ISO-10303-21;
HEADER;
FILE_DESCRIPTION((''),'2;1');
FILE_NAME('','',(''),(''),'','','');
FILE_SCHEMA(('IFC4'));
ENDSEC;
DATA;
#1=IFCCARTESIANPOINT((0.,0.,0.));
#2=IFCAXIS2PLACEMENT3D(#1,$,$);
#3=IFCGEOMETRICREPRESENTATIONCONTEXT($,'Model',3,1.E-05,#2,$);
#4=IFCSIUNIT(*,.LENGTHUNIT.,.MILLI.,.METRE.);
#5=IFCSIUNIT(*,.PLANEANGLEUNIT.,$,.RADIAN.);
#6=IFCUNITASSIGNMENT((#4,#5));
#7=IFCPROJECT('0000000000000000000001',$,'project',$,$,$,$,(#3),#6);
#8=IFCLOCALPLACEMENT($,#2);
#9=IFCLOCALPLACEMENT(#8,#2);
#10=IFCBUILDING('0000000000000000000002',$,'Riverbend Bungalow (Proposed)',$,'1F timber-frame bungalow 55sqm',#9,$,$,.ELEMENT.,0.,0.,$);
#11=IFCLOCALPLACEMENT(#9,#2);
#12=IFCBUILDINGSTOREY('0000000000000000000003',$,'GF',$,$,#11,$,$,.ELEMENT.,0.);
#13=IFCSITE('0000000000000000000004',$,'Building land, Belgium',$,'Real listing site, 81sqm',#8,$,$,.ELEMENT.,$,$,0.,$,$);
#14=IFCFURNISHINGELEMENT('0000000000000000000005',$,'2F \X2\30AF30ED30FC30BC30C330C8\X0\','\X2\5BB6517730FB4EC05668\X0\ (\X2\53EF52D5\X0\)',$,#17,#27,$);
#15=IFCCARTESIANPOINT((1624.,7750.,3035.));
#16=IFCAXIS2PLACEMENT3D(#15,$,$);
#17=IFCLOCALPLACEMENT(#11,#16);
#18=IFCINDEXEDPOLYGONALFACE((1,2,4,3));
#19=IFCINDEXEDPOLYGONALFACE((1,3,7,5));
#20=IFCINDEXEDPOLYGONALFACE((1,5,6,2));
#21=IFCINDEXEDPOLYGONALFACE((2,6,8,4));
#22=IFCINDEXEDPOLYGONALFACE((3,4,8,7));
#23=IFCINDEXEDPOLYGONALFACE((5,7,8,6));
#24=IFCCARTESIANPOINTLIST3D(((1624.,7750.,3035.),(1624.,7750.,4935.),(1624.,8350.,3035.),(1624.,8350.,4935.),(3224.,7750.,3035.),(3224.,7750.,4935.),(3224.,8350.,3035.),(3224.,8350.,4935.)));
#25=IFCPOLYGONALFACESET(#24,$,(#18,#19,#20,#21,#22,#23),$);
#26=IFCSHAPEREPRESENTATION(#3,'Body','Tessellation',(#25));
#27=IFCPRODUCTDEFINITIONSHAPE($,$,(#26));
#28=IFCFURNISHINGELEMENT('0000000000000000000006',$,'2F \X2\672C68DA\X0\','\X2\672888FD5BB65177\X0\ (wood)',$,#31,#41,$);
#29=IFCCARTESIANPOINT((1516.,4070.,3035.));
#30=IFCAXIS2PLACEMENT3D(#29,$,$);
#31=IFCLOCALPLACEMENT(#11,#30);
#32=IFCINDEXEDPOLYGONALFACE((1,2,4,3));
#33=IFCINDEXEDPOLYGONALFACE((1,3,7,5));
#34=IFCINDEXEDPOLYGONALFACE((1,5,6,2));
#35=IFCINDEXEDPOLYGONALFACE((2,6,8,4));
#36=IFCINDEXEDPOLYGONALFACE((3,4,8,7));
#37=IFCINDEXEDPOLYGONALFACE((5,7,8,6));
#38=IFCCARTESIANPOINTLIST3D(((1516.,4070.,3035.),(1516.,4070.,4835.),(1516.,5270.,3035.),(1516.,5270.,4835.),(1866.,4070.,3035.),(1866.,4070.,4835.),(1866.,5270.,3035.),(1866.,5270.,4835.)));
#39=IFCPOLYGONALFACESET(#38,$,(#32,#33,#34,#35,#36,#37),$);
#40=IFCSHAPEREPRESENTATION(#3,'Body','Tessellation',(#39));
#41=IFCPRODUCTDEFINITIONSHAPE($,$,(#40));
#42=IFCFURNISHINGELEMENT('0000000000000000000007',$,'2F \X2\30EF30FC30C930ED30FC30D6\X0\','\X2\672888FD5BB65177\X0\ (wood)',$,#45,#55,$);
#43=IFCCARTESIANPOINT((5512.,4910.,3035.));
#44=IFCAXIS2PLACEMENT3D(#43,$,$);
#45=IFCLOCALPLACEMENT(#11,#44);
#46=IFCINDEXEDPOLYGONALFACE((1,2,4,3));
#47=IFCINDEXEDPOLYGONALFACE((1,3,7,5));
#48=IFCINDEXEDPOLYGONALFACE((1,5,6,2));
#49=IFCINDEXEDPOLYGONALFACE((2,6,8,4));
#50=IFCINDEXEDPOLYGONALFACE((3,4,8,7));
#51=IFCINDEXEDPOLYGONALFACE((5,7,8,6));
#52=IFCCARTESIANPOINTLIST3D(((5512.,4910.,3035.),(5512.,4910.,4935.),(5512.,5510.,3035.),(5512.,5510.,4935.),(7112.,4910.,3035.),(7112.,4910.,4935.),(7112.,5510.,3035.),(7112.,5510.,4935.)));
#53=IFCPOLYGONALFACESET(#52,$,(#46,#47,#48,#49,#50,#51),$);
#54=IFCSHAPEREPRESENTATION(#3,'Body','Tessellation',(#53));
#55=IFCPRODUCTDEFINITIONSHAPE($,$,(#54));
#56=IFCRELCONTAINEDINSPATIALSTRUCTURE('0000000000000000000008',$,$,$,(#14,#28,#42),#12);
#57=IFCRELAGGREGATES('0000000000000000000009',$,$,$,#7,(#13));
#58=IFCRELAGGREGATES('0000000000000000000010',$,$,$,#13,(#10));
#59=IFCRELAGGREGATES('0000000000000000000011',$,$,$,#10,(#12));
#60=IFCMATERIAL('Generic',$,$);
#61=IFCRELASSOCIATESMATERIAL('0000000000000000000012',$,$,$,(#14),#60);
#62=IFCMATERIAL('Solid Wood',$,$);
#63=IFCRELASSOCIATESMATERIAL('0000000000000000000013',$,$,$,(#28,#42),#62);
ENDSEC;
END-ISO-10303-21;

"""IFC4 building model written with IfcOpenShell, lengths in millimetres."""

from ifc_helpers import new_model, si_unit, frame, frame_2d, origin, place, context, project, spatial, rectangle, extrude, material, element, save


model = new_model("IFC4")

# Units and contexts
model_context = context("Model", 3, precision=1e-05, world=origin())
ifc_project = project(units=[si_unit("LENGTHUNIT", "METRE", prefix="MILLI"), si_unit("PLANEANGLEUNIT", "RADIAN")], contexts=[model_context])

# Site, building, storey
site_placement = place(None, origin())
site = spatial("IfcSite", under=ifc_project, at=site_placement, Name="Building land, Belgium", ObjectType="Real listing site, 81sqm", CompositionType="ELEMENT", RefElevation=0.0)
building_placement = place(site_placement, origin())
building = spatial("IfcBuilding", under=site, at=building_placement, Name="Riverbend Bungalow (Proposed)", ObjectType="1F timber-frame bungalow 55sqm", CompositionType="ELEMENT", ElevationOfRefHeight=0.0, ElevationOfTerrain=0.0)
storey_placement = place(building_placement, origin())
storey = spatial("IfcBuildingStorey", under=building, at=storey_placement, Name="GF", CompositionType="ELEMENT", Elevation=0.0)

# Shared definitions
ifc_material_1 = material(Name="Solid Wood")

# Shared definitions
ifc_material_2 = material(Name="Generic")

# Furnishing elements
furnishing_1_placement = place(storey_placement, frame((1624.0, 7750.0, 3035.0)))
element("IfcFurnishingElement", 1, at=furnishing_1_placement, inside=storey, material=ifc_material_2, Name="2F クローゼット", Description="家具・什器 (可動)", context=model_context, shape_type="SweptSolid", body=[
    extrude(rectangle(XDim=1600.0, YDim=600.0, at=frame_2d((800.0, 300.0))), frame((1624.0, 7750.0, 3035.0)), (0.0, 0.0, 1.0), 1900.0),
])
furnishing_2_placement = place(storey_placement, frame((1516.0, 4070.0, 3035.0)))
element("IfcFurnishingElement", 2, at=furnishing_2_placement, inside=storey, material=ifc_material_1, Name="2F 本棚", Description="木製家具 (wood)", context=model_context, shape_type="SweptSolid", body=[
    extrude(rectangle(XDim=350.0, YDim=1200.0, at=frame_2d((175.0, 600.0))), frame((1516.0, 4070.0, 3035.0)), (0.0, 0.0, 1.0), 1800.0),
])
furnishing_3_placement = place(storey_placement, frame((5512.0, 4910.0, 3035.0)))
element("IfcFurnishingElement", 3, at=furnishing_3_placement, inside=storey, material=ifc_material_1, Name="2F ワードローブ", Description="木製家具 (wood)", context=model_context, shape_type="SweptSolid", body=[
    extrude(rectangle(XDim=1600.0, YDim=600.0, at=frame_2d((800.0, 300.0))), frame((5512.0, 4910.0, 3035.0)), (0.0, 0.0, 1.0), 1900.0),
])

save(model, "model.ifc")
